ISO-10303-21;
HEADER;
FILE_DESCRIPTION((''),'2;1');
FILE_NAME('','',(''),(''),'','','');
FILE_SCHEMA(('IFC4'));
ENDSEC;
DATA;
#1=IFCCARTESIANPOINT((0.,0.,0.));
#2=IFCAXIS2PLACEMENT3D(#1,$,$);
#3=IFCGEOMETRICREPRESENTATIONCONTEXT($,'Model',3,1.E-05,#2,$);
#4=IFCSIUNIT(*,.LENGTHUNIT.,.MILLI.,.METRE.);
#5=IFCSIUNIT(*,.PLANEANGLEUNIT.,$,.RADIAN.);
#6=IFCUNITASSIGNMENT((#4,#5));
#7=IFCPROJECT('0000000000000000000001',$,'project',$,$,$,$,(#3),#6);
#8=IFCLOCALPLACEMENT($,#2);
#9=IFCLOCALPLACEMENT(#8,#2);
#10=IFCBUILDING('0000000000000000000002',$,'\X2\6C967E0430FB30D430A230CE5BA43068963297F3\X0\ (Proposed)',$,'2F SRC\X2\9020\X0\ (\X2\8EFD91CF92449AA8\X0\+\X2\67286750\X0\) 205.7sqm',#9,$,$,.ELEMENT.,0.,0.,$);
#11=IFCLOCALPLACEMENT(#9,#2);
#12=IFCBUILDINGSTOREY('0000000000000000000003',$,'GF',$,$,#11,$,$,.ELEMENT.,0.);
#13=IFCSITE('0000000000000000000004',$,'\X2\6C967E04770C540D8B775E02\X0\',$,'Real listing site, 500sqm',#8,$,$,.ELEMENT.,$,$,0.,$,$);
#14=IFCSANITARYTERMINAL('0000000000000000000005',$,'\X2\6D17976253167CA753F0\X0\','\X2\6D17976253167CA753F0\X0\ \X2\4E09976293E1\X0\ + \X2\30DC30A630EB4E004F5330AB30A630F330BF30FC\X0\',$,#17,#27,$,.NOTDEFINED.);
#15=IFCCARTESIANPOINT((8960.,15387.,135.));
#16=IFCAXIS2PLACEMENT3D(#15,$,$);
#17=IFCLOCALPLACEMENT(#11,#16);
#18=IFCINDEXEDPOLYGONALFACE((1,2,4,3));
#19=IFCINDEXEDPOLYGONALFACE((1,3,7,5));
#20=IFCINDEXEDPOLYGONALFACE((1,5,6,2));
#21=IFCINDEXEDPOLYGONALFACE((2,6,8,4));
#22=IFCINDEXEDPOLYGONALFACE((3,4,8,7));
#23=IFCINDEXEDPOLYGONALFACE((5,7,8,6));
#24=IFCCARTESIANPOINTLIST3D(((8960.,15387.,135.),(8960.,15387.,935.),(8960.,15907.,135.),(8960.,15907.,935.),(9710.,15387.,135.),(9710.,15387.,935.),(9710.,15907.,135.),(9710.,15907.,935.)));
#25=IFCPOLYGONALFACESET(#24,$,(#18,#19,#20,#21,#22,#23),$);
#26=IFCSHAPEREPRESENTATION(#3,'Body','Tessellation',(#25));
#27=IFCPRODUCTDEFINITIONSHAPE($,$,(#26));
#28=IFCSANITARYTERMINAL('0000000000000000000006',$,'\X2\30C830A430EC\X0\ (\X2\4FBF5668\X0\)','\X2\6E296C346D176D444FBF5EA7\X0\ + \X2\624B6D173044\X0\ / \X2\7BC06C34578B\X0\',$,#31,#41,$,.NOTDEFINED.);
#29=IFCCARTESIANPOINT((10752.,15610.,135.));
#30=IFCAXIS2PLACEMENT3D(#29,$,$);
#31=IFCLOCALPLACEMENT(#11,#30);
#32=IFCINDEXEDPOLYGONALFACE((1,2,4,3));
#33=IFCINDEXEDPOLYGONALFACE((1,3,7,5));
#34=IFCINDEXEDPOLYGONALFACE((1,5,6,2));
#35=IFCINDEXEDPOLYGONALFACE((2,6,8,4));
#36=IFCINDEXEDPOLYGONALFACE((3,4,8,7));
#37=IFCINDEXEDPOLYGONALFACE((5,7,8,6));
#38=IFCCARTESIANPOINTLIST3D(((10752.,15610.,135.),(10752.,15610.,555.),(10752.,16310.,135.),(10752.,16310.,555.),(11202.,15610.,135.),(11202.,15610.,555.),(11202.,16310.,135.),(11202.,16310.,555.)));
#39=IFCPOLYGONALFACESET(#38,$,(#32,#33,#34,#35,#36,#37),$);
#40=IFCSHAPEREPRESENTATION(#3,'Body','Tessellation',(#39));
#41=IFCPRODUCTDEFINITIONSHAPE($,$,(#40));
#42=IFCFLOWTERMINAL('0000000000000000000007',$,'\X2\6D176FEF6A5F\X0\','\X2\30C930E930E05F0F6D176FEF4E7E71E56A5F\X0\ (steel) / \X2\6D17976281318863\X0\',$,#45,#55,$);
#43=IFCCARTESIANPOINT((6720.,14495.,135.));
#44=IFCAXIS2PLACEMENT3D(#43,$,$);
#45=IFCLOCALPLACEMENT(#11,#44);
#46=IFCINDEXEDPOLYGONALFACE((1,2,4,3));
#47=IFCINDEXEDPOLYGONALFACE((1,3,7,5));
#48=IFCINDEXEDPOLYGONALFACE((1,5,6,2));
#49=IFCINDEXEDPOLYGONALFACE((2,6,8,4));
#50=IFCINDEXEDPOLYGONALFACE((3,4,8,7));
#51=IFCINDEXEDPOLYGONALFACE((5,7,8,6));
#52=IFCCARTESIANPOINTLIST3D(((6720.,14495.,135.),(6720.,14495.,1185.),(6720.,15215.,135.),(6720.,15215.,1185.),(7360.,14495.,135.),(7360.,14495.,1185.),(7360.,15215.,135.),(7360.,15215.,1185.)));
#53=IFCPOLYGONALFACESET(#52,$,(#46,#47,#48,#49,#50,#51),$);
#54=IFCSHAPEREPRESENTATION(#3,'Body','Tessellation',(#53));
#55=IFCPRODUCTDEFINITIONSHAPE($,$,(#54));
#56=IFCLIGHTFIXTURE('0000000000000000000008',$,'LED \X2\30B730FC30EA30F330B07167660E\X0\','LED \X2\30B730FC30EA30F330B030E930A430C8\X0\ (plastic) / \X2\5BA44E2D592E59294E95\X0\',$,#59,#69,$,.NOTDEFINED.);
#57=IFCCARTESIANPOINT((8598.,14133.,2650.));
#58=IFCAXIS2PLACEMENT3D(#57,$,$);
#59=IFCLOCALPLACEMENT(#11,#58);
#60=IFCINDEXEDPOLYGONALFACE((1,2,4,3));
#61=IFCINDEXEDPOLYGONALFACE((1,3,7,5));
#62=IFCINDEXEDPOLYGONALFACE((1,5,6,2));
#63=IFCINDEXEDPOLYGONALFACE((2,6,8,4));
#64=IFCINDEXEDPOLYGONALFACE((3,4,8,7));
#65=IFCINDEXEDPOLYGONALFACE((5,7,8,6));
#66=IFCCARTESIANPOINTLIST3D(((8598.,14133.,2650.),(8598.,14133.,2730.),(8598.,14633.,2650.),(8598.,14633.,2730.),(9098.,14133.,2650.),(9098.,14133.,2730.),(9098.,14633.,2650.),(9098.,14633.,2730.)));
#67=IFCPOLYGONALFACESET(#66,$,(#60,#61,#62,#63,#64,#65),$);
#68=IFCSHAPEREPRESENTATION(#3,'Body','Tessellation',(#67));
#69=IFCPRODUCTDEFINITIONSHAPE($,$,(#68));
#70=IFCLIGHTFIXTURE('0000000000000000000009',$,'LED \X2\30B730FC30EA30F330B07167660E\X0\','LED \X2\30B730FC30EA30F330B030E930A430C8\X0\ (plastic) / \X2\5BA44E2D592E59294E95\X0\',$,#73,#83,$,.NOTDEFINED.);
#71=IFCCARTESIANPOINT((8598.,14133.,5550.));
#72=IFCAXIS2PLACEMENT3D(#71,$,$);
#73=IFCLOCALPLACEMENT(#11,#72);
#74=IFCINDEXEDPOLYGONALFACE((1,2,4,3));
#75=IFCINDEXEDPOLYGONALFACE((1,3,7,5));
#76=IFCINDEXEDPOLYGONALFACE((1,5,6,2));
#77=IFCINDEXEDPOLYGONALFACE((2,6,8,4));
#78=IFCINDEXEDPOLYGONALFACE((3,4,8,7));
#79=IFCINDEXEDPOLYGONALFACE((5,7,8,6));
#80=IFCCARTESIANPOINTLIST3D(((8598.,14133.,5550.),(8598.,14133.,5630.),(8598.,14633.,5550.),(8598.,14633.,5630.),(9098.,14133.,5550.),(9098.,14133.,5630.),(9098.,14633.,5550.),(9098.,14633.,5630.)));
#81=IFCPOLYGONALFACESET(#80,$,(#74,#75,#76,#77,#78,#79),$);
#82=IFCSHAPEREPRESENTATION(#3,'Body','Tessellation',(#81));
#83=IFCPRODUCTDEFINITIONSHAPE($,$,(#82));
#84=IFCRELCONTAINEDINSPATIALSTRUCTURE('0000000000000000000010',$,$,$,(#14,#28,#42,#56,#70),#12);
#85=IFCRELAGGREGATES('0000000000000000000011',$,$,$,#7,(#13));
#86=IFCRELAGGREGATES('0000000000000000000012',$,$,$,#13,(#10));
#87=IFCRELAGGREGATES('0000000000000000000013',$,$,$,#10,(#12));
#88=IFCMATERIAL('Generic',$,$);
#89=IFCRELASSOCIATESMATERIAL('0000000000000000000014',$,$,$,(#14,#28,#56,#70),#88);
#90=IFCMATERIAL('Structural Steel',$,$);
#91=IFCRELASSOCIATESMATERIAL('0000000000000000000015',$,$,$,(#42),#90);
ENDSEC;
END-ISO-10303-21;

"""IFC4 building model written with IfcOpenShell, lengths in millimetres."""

from ifc_helpers import new_model, si_unit, frame, frame_2d, origin, place, context, project, spatial, rectangle, extrude, material, element, save


model = new_model("IFC4")

# Units and contexts
model_context = context("Model", 3, precision=1e-05, world=origin())
ifc_project = project(units=[si_unit("LENGTHUNIT", "METRE", prefix="MILLI"), si_unit("PLANEANGLEUNIT", "RADIAN")], contexts=[model_context])

# Site, building, storey
site_placement = place(None, origin())
site = spatial("IfcSite", under=ifc_project, at=site_placement, Name="沖縄県名護市", ObjectType="Real listing site, 500sqm", CompositionType="ELEMENT", RefElevation=0.0)
building_placement = place(site_placement, origin())
building = spatial("IfcBuilding", under=site, at=building_placement, Name="沖縄・ピアノ室と防音 (Proposed)", ObjectType="2F SRC造 (軽量鉄骨+木材) 205.7sqm", CompositionType="ELEMENT", ElevationOfRefHeight=0.0, ElevationOfTerrain=0.0)
storey_placement = place(building_placement, origin())
storey = spatial("IfcBuildingStorey", under=building, at=storey_placement, Name="GF", CompositionType="ELEMENT", Elevation=0.0)

# Sanitary terminals
ifc_material_1 = material(Name="Generic")
sanitary_terminal_1_placement = place(storey_placement, frame((8960.0, 15387.0, 135.0)))
element("IfcSanitaryTerminal", 1, at=sanitary_terminal_1_placement, inside=storey, material=ifc_material_1, Name="洗面化粧台", Description="洗面化粧台 三面鏡 + ボウル一体カウンター", PredefinedType="NOTDEFINED", context=model_context, shape_type="SweptSolid", body=[
    extrude(rectangle(XDim=750.0, YDim=520.0, at=frame_2d((375.0, 260.0))), frame((8960.0, 15387.0, 135.0)), (0.0, 0.0, 1.0), 800.0),
])
sanitary_terminal_2_placement = place(storey_placement, frame((10752.0, 15610.0, 135.0)))
element("IfcSanitaryTerminal", 2, at=sanitary_terminal_2_placement, inside=storey, material=ifc_material_1, Name="トイレ (便器)", Description="温水洗浄便座 + 手洗い / 節水型", PredefinedType="NOTDEFINED", context=model_context, shape_type="SweptSolid", body=[
    extrude(rectangle(XDim=450.0, YDim=700.0, at=frame_2d((225.0, 350.0))), frame((10752.0, 15610.0, 135.0)), (0.0, 0.0, 1.0), 420.0),
])

# Flow terminal
ifc_material_2 = material(Name="Structural Steel")
flow_terminal_placement = place(storey_placement, frame((6720.0, 14495.0, 135.0)))
element("IfcFlowTerminal", 3, at=flow_terminal_placement, inside=storey, material=ifc_material_2, Name="洗濯機", Description="ドラム式洗濯乾燥機 (steel) / 洗面脱衣", context=model_context, shape_type="SweptSolid", body=[
    extrude(rectangle(XDim=640.0, YDim=720.0, at=frame_2d((320.0, 360.0))), frame((6720.0, 14495.0, 135.0)), (0.0, 0.0, 1.0), 1050.0),
])

# Light fixtures
light_fixture_1_placement = place(storey_placement, frame((8598.0, 14133.0, 2650.0)))
element("IfcLightFixture", 4, at=light_fixture_1_placement, inside=storey, material=ifc_material_1, Name="LED シーリング照明", Description="LED シーリングライト (plastic) / 室中央天井", PredefinedType="NOTDEFINED", context=model_context, shape_type="SweptSolid", body=[
    extrude(rectangle(XDim=500.0, YDim=500.0, at=frame_2d((250.0, 250.0))), frame((8598.0, 14133.0, 2650.0)), (0.0, 0.0, 1.0), 80.0),
])
light_fixture_2_placement = place(storey_placement, frame((8598.0, 14133.0, 5550.0)))
element("IfcLightFixture", 5, at=light_fixture_2_placement, inside=storey, material=ifc_material_1, Name="LED シーリング照明", Description="LED シーリングライト (plastic) / 室中央天井", PredefinedType="NOTDEFINED", context=model_context, shape_type="SweptSolid", body=[
    extrude(rectangle(XDim=500.0, YDim=500.0, at=frame_2d((250.0, 250.0))), frame((8598.0, 14133.0, 5550.0)), (0.0, 0.0, 1.0), 80.0),
])

save(model, "model.ifc")
